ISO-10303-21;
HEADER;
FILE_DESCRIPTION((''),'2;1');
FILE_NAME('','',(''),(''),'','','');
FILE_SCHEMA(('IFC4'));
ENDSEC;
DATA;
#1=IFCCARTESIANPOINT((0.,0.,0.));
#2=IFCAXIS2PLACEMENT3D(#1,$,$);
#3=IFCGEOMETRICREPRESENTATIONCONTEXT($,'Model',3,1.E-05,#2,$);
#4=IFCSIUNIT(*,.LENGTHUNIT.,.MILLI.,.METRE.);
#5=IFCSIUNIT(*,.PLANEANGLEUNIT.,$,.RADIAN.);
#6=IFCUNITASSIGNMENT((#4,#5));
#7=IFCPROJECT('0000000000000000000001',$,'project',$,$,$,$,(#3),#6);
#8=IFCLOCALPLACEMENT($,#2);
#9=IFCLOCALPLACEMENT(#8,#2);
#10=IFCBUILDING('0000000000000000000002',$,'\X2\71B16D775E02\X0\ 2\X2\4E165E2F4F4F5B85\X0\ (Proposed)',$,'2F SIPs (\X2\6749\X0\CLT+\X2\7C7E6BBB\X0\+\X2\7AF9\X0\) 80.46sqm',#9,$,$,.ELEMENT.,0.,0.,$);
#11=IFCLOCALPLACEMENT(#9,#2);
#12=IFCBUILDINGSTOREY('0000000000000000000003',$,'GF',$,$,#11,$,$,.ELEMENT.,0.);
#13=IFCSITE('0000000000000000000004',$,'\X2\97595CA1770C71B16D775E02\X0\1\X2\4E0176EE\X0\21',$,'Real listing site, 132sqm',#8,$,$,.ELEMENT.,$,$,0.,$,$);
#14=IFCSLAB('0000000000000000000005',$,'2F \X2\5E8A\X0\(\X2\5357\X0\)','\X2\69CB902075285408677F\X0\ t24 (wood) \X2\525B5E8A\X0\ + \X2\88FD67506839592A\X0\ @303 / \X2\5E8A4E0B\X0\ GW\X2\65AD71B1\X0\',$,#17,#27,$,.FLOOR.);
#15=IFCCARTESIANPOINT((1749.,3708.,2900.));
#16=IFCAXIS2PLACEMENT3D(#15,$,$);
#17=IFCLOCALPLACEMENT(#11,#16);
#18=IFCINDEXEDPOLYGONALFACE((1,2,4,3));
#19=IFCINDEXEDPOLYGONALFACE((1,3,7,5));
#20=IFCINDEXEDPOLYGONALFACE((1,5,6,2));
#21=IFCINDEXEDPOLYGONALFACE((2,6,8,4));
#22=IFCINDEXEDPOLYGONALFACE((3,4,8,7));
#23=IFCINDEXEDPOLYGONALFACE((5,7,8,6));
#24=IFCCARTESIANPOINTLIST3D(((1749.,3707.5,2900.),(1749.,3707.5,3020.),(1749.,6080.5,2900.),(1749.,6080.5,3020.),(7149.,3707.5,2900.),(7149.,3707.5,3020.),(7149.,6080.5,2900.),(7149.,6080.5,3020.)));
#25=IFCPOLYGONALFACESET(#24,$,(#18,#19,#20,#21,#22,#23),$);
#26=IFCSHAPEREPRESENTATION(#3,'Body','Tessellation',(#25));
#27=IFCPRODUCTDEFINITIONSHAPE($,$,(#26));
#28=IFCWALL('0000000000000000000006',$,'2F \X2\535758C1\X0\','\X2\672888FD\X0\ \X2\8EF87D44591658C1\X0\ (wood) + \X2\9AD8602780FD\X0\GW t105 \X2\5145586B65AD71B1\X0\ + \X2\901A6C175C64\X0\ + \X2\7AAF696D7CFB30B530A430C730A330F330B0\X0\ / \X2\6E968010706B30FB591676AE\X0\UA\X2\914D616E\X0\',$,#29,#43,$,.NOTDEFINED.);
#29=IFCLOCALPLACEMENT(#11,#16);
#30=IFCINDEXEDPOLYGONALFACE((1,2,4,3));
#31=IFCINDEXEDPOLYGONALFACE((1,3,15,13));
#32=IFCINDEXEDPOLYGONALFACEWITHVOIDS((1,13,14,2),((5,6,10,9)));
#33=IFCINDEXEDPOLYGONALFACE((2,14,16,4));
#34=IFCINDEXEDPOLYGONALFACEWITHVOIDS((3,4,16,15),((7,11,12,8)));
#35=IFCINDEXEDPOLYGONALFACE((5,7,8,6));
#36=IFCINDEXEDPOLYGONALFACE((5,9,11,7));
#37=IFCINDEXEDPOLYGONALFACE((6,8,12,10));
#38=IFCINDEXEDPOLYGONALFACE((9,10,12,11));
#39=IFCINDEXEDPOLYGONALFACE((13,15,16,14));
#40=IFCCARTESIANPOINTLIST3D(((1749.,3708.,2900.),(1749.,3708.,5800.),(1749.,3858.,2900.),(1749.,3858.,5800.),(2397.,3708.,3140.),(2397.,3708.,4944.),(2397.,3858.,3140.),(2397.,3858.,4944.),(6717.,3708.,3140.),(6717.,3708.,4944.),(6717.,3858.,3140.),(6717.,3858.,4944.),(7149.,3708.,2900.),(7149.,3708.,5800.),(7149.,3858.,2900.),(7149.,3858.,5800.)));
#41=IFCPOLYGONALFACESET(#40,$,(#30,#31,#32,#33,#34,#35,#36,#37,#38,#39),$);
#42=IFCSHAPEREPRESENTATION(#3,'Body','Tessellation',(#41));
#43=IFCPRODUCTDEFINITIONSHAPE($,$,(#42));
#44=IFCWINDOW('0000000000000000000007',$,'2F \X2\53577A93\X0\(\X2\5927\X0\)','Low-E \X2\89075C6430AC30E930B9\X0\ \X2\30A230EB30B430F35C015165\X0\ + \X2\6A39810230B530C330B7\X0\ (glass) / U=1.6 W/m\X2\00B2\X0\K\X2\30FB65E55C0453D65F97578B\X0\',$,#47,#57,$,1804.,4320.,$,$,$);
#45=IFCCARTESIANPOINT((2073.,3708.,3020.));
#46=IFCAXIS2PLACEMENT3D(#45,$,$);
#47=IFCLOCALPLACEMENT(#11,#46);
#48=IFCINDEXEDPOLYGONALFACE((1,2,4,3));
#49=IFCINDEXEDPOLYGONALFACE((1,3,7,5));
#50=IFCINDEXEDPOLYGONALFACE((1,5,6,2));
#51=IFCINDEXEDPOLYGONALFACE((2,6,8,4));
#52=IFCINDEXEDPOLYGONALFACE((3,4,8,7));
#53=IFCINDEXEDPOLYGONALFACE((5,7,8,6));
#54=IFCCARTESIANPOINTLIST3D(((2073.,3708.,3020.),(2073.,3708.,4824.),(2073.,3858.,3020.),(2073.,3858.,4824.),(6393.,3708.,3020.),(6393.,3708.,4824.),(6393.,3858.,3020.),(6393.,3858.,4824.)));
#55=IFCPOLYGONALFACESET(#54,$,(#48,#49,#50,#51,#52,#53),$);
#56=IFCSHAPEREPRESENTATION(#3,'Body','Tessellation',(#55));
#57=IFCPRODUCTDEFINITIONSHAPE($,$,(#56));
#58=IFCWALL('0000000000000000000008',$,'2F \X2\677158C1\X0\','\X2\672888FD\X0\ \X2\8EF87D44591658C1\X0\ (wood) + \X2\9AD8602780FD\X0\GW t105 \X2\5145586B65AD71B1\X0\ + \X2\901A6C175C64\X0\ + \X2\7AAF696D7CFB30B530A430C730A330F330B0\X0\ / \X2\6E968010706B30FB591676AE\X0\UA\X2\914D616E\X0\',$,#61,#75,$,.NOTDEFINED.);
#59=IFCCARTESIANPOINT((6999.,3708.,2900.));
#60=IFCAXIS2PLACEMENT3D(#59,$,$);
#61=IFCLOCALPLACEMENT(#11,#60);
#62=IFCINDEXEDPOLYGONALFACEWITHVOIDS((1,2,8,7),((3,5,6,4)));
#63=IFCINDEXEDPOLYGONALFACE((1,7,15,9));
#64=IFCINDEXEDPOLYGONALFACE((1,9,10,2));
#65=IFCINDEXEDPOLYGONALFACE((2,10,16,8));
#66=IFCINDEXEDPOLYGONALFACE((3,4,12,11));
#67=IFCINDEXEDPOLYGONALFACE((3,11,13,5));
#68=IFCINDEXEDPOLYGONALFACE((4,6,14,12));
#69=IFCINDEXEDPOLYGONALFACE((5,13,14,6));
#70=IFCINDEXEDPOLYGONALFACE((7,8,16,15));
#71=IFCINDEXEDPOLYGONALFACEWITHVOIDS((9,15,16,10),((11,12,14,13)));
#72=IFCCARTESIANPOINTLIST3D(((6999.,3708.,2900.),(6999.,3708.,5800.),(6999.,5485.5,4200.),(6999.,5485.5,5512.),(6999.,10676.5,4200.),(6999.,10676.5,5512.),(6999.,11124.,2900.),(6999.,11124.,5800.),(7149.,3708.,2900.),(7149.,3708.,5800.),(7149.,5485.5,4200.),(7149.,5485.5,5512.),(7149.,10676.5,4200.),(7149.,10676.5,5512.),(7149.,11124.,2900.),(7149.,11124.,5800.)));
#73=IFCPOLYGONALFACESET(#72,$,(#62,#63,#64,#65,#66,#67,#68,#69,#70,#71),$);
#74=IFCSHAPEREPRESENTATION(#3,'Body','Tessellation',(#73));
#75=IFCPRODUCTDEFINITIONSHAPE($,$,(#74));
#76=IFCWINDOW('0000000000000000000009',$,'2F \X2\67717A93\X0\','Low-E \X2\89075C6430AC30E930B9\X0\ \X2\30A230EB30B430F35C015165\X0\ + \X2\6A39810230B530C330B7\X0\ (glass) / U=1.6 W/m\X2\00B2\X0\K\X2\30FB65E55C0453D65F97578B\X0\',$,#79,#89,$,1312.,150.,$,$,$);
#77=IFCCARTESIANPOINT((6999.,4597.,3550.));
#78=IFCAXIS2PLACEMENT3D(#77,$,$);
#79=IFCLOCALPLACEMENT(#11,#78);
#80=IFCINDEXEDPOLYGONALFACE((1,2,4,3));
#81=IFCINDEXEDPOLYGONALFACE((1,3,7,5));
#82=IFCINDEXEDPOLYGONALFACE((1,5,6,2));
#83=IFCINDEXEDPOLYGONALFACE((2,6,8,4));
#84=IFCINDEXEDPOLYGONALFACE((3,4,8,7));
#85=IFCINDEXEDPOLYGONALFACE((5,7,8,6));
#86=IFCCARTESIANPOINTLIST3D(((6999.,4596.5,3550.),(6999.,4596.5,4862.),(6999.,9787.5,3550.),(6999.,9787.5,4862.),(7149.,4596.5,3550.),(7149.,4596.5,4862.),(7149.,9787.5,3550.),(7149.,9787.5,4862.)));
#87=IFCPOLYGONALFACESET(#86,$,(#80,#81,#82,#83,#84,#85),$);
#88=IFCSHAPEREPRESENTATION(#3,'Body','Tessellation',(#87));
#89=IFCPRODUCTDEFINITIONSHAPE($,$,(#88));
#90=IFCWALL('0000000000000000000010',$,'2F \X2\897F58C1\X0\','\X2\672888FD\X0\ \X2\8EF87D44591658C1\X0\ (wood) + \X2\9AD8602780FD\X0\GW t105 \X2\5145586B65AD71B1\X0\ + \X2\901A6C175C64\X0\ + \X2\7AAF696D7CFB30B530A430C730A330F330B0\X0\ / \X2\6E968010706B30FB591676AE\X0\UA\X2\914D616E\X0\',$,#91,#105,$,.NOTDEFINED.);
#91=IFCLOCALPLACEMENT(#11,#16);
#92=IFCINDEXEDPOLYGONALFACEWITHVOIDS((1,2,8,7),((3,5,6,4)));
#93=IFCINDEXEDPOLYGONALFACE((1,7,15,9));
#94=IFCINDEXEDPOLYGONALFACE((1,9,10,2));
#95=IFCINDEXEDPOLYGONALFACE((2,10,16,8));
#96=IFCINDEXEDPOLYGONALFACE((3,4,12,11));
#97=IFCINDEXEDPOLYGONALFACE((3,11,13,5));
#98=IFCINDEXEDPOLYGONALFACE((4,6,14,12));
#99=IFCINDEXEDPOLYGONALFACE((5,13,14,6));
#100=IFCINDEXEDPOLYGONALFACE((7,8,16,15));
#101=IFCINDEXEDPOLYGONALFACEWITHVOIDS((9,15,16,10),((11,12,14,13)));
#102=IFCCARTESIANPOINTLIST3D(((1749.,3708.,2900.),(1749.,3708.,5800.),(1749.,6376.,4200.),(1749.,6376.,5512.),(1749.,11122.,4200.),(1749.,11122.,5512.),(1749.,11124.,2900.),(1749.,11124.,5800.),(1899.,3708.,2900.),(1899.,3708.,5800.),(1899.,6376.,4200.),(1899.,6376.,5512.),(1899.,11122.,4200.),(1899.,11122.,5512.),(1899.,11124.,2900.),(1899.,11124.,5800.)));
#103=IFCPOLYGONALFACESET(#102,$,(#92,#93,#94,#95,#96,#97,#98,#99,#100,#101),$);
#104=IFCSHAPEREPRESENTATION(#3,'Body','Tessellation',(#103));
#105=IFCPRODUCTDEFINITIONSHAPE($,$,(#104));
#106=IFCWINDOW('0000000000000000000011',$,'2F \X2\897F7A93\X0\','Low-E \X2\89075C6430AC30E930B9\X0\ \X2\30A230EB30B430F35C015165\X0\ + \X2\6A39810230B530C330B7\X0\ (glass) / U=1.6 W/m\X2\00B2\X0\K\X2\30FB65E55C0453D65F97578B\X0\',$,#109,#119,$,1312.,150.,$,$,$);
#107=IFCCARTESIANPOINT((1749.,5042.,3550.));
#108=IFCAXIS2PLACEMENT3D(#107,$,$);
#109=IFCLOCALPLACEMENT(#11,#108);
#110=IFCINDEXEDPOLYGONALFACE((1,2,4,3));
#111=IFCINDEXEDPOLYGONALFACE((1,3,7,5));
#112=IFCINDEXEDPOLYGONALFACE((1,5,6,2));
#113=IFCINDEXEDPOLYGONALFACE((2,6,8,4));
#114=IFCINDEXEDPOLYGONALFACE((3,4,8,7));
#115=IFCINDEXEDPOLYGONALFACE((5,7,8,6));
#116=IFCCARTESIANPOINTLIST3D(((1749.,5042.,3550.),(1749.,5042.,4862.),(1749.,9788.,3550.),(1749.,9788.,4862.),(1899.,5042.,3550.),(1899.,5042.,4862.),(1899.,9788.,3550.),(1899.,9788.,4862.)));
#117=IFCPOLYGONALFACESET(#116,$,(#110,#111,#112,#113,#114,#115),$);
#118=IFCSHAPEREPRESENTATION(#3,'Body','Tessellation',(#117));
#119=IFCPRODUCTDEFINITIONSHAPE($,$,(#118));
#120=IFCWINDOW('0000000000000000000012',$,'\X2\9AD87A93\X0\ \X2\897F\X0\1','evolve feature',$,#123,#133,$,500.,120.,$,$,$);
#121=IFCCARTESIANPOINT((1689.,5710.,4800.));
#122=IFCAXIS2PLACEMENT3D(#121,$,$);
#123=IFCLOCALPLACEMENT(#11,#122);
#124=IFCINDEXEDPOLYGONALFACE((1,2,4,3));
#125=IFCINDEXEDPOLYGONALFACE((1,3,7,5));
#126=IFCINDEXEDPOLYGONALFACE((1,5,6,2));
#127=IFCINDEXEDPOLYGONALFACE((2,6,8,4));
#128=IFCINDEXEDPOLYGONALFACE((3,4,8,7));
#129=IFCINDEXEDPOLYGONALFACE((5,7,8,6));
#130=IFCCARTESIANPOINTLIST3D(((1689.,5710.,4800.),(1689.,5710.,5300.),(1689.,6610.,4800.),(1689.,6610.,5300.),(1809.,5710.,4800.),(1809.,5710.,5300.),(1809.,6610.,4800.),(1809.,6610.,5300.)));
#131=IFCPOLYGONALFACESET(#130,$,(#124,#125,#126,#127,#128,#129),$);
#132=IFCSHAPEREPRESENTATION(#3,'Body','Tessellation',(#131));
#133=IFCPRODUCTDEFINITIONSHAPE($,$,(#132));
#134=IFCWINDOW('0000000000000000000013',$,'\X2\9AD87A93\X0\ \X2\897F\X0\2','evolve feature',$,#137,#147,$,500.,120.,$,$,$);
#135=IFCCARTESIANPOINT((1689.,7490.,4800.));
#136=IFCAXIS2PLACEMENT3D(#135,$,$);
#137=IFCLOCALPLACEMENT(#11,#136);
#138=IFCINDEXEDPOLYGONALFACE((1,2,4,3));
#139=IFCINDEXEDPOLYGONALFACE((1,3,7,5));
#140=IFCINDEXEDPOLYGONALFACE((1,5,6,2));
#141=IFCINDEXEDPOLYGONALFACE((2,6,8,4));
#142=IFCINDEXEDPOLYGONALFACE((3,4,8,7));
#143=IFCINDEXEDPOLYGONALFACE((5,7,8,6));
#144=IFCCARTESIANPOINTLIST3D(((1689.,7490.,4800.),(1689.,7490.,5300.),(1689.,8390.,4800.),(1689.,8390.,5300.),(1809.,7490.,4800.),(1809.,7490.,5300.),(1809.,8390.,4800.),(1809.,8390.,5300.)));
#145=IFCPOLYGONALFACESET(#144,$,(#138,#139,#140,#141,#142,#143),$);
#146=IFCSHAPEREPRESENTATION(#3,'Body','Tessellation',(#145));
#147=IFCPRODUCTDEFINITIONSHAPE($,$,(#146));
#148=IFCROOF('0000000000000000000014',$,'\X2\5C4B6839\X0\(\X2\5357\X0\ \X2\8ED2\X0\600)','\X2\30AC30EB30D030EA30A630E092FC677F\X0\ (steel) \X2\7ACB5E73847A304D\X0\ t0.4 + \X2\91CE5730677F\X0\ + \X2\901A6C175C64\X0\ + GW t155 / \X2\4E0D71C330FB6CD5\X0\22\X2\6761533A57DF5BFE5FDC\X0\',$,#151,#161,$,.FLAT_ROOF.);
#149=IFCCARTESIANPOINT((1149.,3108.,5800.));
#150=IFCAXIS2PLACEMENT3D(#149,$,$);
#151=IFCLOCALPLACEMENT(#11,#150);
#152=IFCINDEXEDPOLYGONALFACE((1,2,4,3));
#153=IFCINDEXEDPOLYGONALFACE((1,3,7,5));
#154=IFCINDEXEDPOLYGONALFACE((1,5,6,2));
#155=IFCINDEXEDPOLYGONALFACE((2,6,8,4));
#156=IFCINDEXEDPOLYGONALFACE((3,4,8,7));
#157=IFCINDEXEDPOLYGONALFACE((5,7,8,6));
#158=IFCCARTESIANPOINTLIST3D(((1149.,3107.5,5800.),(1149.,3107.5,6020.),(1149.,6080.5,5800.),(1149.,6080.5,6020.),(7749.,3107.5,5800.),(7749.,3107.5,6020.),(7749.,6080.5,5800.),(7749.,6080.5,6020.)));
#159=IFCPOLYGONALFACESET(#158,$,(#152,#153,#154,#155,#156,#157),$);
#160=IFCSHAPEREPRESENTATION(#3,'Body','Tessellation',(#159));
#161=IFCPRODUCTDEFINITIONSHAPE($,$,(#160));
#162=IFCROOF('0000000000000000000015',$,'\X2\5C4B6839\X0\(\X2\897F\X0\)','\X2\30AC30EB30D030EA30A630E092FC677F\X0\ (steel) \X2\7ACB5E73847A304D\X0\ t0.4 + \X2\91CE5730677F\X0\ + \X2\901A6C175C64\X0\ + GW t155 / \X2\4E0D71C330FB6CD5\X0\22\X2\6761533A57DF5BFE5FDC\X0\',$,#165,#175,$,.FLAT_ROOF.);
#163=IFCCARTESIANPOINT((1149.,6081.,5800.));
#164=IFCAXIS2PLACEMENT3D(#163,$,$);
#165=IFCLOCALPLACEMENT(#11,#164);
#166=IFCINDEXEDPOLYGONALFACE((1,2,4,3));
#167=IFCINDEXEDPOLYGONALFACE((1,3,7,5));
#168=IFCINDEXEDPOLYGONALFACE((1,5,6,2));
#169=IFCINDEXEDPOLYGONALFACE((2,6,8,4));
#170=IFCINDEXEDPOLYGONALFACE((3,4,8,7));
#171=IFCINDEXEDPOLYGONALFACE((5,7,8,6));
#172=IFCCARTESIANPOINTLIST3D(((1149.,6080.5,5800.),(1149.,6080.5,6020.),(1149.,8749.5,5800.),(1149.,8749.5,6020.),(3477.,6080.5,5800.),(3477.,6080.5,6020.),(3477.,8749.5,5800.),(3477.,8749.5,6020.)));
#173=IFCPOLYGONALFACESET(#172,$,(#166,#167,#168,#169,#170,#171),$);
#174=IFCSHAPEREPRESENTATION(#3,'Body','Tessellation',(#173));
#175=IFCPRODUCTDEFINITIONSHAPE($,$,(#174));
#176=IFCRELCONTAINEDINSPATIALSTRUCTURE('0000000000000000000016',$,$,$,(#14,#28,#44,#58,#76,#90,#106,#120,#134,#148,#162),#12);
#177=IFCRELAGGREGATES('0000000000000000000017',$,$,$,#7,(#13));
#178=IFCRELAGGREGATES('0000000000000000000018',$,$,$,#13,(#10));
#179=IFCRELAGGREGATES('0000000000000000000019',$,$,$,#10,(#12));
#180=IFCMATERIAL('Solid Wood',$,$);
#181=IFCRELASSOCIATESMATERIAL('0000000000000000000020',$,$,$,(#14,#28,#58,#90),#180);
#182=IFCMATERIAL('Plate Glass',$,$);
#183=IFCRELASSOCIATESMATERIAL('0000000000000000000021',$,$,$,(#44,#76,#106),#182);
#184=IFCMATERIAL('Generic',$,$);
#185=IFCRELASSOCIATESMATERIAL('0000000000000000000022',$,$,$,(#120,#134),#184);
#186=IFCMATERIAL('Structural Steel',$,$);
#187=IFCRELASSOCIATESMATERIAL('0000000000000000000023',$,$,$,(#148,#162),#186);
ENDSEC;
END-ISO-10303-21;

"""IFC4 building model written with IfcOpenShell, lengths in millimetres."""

from ifc_helpers import new_model, si_unit, frame, frame_2d, origin, place, context, project, spatial, rectangle, extrude, material, element, fill, save


model = new_model("IFC4")

# Units and contexts
model_context = context("Model", 3, precision=1e-05, world=origin())
ifc_project = project(units=[si_unit("LENGTHUNIT", "METRE", prefix="MILLI"), si_unit("PLANEANGLEUNIT", "RADIAN")], contexts=[model_context])

# Site, building, storey
site_placement = place(None, origin())
site = spatial("IfcSite", under=ifc_project, at=site_placement, Name="静岡県熱海市1丁目21", ObjectType="Real listing site, 132sqm", CompositionType="ELEMENT", RefElevation=0.0)
building_placement = place(site_placement, origin())
building = spatial("IfcBuilding", under=site, at=building_placement, Name="熱海市 2世帯住宅 (Proposed)", ObjectType="2F SIPs (杉CLT+籾殻+竹) 80.46sqm", CompositionType="ELEMENT", ElevationOfRefHeight=0.0, ElevationOfTerrain=0.0)
storey_placement = place(building_placement, origin())
storey = spatial("IfcBuildingStorey", under=building, at=storey_placement, Name="GF", CompositionType="ELEMENT", Elevation=0.0)

# Slab
ifc_material_1 = material(Name="Solid Wood")
slab_placement = place(storey_placement, frame((1749.0, 3708.0, 2900.0)))
element("IfcSlab", 1, at=slab_placement, inside=storey, material=ifc_material_1, Name="2F 床(南)", Description="構造用合板 t24 (wood) 剛床 + 製材根太 @303 / 床下 GW断熱", PredefinedType="FLOOR", context=model_context, shape_type="SweptSolid", body=[
    extrude(rectangle(XDim=5400.0, YDim=2373.0, at=frame_2d((2700.0, 1186.0))), frame((1749.0, 3708.0, 2900.0)), (0.0, 0.0, 1.0), 120.0),
])

# Walls, openings, windows
wall_1_placement = place(storey_placement, frame((1749.0, 3708.0, 2900.0)))
wall_1 = element("IfcWall", 2, at=wall_1_placement, inside=storey, material=ifc_material_1, Name="2F 南壁", Description="木製 軸組外壁 (wood) + 高性能GW t105 充填断熱 + 通気層 + 窯業系サイディング / 準耐火・外皮UA配慮", PredefinedType="NOTDEFINED", context=model_context, shape_type="SweptSolid", body=[
    extrude(rectangle(XDim=5400.0, YDim=150.0, at=frame_2d((2700.0, 75.0))), frame((1749.0, 3708.0, 2900.0)), (0.0, 0.0, 1.0), 2900.0),
])
opening_1_placement = place(storey_placement, frame((2073.0, 3708.0, 3020.0)))
opening_1 = element("IfcOpeningElement", 3, at=opening_1_placement, cuts=wall_1, PredefinedType="NOTDEFINED", context=model_context, shape_type="SweptSolid", body=[
    extrude(rectangle(XDim=4320.0, YDim=150.0, at=frame_2d((2160.0, 75.0))), frame((2073.0, 3708.0, 3020.0)), (0.0, 0.0, 1.0), 1804.0),
])
ifc_material_2 = material(Name="Plate Glass")
window_1_placement = place(storey_placement, frame((2073.0, 3708.0, 3020.0)))
window_1 = element("IfcWindow", 4, at=window_1_placement, inside=storey, material=ifc_material_2, Name="2F 南窓(大)", Description="Low-E 複層ガラス アルゴン封入 + 樹脂サッシ (glass) / U=1.6 W/m²K・日射取得型", OverallHeight=1804.0, OverallWidth=4320.0, context=model_context, shape_type="SweptSolid", body=[
    extrude(rectangle(XDim=4320.0, YDim=150.0, at=frame_2d((2160.0, 75.0))), frame((2073.0, 3708.0, 3020.0)), (0.0, 0.0, 1.0), 1804.0),
])
fill(opening_1, window_1)
wall_2_placement = place(storey_placement, frame((6999.0, 3708.0, 2900.0)))
wall_2 = element("IfcWall", 5, at=wall_2_placement, inside=storey, material=ifc_material_1, Name="2F 東壁", Description="木製 軸組外壁 (wood) + 高性能GW t105 充填断熱 + 通気層 + 窯業系サイディング / 準耐火・外皮UA配慮", PredefinedType="NOTDEFINED", context=model_context, shape_type="SweptSolid", body=[
    extrude(rectangle(XDim=150.0, YDim=7416.0, at=frame_2d((75.0, 3708.0))), frame((6999.0, 3708.0, 2900.0)), (0.0, 0.0, 1.0), 2900.0),
])
opening_2_placement = place(storey_placement, frame((6999.0, 4597.0, 3550.0)))
opening_2 = element("IfcOpeningElement", 6, at=opening_2_placement, cuts=wall_2, PredefinedType="NOTDEFINED", context=model_context, shape_type="SweptSolid", body=[
    extrude(rectangle(XDim=150.0, YDim=5191.0, at=frame_2d((75.0, 2595.0))), frame((6999.0, 4597.0, 3550.0)), (0.0, 0.0, 1.0), 1312.0),
])
window_2_placement = place(storey_placement, frame((6999.0, 4597.0, 3550.0)))
window_2 = element("IfcWindow", 7, at=window_2_placement, inside=storey, material=ifc_material_2, Name="2F 東窓", Description="Low-E 複層ガラス アルゴン封入 + 樹脂サッシ (glass) / U=1.6 W/m²K・日射取得型", OverallHeight=1312.0, OverallWidth=150.0, context=model_context, shape_type="SweptSolid", body=[
    extrude(rectangle(XDim=150.0, YDim=5191.0, at=frame_2d((75.0, 2595.0))), frame((6999.0, 4597.0, 3550.0)), (0.0, 0.0, 1.0), 1312.0),
])
fill(opening_2, window_2)

# Wall, openings, windows
wall_3_placement = place(storey_placement, frame((1749.0, 3708.0, 2900.0)))
wall_3 = element("IfcWall", 8, at=wall_3_placement, inside=storey, material=ifc_material_1, Name="2F 西壁", Description="木製 軸組外壁 (wood) + 高性能GW t105 充填断熱 + 通気層 + 窯業系サイディング / 準耐火・外皮UA配慮", PredefinedType="NOTDEFINED", context=model_context, shape_type="SweptSolid", body=[
    extrude(rectangle(XDim=150.0, YDim=7416.0, at=frame_2d((75.0, 3708.0))), frame((1749.0, 3708.0, 2900.0)), (0.0, 0.0, 1.0), 2900.0),
])
opening_3_placement = place(storey_placement, frame((1749.0, 5042.0, 3550.0)))
opening_3 = element("IfcOpeningElement", 9, at=opening_3_placement, cuts=wall_3, PredefinedType="NOTDEFINED", context=model_context, shape_type="SweptSolid", body=[
    extrude(rectangle(XDim=150.0, YDim=4746.0, at=frame_2d((75.0, 2373.0))), frame((1749.0, 5042.0, 3550.0)), (0.0, 0.0, 1.0), 1312.0),
])
opening_4_placement = place(storey_placement, frame((1689.0, 5710.0, 4800.0)))
opening_4 = element("IfcOpeningElement", 10, at=opening_4_placement, cuts=wall_3, PredefinedType="NOTDEFINED", context=model_context, shape_type="SweptSolid", body=[
    extrude(rectangle(XDim=120.0, YDim=900.0, at=frame_2d((60.0, 450.0))), frame((1689.0, 5710.0, 4800.0)), (0.0, 0.0, 1.0), 500.0),
])
opening_5_placement = place(storey_placement, frame((1689.0, 7490.0, 4800.0)))
opening_5 = element("IfcOpeningElement", 11, at=opening_5_placement, cuts=wall_3, PredefinedType="NOTDEFINED", context=model_context, shape_type="SweptSolid", body=[
    extrude(rectangle(XDim=120.0, YDim=900.0, at=frame_2d((60.0, 450.0))), frame((1689.0, 7490.0, 4800.0)), (0.0, 0.0, 1.0), 500.0),
])
window_3_placement = place(storey_placement, frame((1749.0, 5042.0, 3550.0)))
window_3 = element("IfcWindow", 12, at=window_3_placement, inside=storey, material=ifc_material_2, Name="2F 西窓", Description="Low-E 複層ガラス アルゴン封入 + 樹脂サッシ (glass) / U=1.6 W/m²K・日射取得型", OverallHeight=1312.0, OverallWidth=150.0, context=model_context, shape_type="SweptSolid", body=[
    extrude(rectangle(XDim=150.0, YDim=4746.0, at=frame_2d((75.0, 2373.0))), frame((1749.0, 5042.0, 3550.0)), (0.0, 0.0, 1.0), 1312.0),
])
fill(opening_3, window_3)
ifc_material_3 = material(Name="Generic")
window_4_placement = place(storey_placement, frame((1689.0, 5710.0, 4800.0)))
window_4 = element("IfcWindow", 13, at=window_4_placement, inside=storey, material=ifc_material_3, Name="高窓 西1", Description="evolve feature", OverallHeight=500.0, OverallWidth=120.0, context=model_context, shape_type="SweptSolid", body=[
    extrude(rectangle(XDim=120.0, YDim=900.0, at=frame_2d((60.0, 450.0))), frame((1689.0, 5710.0, 4800.0)), (0.0, 0.0, 1.0), 500.0),
])
fill(opening_4, window_4)
window_5_placement = place(storey_placement, frame((1689.0, 7490.0, 4800.0)))
window_5 = element("IfcWindow", 14, at=window_5_placement, inside=storey, material=ifc_material_3, Name="高窓 西2", Description="evolve feature", OverallHeight=500.0, OverallWidth=120.0, context=model_context, shape_type="SweptSolid", body=[
    extrude(rectangle(XDim=120.0, YDim=900.0, at=frame_2d((60.0, 450.0))), frame((1689.0, 7490.0, 4800.0)), (0.0, 0.0, 1.0), 500.0),
])
fill(opening_5, window_5)

# Roofs
ifc_material_4 = material(Name="Structural Steel")
roof_1_placement = place(storey_placement, frame((1149.0, 3108.0, 5800.0)))
element("IfcRoof", 15, at=roof_1_placement, inside=storey, material=ifc_material_4, Name="屋根(南 軒600)", Description="ガルバリウム鋼板 (steel) 立平葺き t0.4 + 野地板 + 通気層 + GW t155 / 不燃・法22条区域対応", PredefinedType="FLAT_ROOF", context=model_context, shape_type="SweptSolid", body=[
    extrude(rectangle(XDim=6600.0, YDim=2973.0, at=frame_2d((3300.0, 1486.0))), frame((1149.0, 3108.0, 5800.0)), (0.0, 0.0, 1.0), 220.0),
])
roof_2_placement = place(storey_placement, frame((1149.0, 6081.0, 5800.0)))
element("IfcRoof", 16, at=roof_2_placement, inside=storey, material=ifc_material_4, Name="屋根(西)", Description="ガルバリウム鋼板 (steel) 立平葺き t0.4 + 野地板 + 通気層 + GW t155 / 不燃・法22条区域対応", PredefinedType="FLAT_ROOF", context=model_context, shape_type="SweptSolid", body=[
    extrude(rectangle(XDim=2328.0, YDim=2669.0, at=frame_2d((1164.0, 1334.0))), frame((1149.0, 6081.0, 5800.0)), (0.0, 0.0, 1.0), 220.0),
])

save(model, "model.ifc")
